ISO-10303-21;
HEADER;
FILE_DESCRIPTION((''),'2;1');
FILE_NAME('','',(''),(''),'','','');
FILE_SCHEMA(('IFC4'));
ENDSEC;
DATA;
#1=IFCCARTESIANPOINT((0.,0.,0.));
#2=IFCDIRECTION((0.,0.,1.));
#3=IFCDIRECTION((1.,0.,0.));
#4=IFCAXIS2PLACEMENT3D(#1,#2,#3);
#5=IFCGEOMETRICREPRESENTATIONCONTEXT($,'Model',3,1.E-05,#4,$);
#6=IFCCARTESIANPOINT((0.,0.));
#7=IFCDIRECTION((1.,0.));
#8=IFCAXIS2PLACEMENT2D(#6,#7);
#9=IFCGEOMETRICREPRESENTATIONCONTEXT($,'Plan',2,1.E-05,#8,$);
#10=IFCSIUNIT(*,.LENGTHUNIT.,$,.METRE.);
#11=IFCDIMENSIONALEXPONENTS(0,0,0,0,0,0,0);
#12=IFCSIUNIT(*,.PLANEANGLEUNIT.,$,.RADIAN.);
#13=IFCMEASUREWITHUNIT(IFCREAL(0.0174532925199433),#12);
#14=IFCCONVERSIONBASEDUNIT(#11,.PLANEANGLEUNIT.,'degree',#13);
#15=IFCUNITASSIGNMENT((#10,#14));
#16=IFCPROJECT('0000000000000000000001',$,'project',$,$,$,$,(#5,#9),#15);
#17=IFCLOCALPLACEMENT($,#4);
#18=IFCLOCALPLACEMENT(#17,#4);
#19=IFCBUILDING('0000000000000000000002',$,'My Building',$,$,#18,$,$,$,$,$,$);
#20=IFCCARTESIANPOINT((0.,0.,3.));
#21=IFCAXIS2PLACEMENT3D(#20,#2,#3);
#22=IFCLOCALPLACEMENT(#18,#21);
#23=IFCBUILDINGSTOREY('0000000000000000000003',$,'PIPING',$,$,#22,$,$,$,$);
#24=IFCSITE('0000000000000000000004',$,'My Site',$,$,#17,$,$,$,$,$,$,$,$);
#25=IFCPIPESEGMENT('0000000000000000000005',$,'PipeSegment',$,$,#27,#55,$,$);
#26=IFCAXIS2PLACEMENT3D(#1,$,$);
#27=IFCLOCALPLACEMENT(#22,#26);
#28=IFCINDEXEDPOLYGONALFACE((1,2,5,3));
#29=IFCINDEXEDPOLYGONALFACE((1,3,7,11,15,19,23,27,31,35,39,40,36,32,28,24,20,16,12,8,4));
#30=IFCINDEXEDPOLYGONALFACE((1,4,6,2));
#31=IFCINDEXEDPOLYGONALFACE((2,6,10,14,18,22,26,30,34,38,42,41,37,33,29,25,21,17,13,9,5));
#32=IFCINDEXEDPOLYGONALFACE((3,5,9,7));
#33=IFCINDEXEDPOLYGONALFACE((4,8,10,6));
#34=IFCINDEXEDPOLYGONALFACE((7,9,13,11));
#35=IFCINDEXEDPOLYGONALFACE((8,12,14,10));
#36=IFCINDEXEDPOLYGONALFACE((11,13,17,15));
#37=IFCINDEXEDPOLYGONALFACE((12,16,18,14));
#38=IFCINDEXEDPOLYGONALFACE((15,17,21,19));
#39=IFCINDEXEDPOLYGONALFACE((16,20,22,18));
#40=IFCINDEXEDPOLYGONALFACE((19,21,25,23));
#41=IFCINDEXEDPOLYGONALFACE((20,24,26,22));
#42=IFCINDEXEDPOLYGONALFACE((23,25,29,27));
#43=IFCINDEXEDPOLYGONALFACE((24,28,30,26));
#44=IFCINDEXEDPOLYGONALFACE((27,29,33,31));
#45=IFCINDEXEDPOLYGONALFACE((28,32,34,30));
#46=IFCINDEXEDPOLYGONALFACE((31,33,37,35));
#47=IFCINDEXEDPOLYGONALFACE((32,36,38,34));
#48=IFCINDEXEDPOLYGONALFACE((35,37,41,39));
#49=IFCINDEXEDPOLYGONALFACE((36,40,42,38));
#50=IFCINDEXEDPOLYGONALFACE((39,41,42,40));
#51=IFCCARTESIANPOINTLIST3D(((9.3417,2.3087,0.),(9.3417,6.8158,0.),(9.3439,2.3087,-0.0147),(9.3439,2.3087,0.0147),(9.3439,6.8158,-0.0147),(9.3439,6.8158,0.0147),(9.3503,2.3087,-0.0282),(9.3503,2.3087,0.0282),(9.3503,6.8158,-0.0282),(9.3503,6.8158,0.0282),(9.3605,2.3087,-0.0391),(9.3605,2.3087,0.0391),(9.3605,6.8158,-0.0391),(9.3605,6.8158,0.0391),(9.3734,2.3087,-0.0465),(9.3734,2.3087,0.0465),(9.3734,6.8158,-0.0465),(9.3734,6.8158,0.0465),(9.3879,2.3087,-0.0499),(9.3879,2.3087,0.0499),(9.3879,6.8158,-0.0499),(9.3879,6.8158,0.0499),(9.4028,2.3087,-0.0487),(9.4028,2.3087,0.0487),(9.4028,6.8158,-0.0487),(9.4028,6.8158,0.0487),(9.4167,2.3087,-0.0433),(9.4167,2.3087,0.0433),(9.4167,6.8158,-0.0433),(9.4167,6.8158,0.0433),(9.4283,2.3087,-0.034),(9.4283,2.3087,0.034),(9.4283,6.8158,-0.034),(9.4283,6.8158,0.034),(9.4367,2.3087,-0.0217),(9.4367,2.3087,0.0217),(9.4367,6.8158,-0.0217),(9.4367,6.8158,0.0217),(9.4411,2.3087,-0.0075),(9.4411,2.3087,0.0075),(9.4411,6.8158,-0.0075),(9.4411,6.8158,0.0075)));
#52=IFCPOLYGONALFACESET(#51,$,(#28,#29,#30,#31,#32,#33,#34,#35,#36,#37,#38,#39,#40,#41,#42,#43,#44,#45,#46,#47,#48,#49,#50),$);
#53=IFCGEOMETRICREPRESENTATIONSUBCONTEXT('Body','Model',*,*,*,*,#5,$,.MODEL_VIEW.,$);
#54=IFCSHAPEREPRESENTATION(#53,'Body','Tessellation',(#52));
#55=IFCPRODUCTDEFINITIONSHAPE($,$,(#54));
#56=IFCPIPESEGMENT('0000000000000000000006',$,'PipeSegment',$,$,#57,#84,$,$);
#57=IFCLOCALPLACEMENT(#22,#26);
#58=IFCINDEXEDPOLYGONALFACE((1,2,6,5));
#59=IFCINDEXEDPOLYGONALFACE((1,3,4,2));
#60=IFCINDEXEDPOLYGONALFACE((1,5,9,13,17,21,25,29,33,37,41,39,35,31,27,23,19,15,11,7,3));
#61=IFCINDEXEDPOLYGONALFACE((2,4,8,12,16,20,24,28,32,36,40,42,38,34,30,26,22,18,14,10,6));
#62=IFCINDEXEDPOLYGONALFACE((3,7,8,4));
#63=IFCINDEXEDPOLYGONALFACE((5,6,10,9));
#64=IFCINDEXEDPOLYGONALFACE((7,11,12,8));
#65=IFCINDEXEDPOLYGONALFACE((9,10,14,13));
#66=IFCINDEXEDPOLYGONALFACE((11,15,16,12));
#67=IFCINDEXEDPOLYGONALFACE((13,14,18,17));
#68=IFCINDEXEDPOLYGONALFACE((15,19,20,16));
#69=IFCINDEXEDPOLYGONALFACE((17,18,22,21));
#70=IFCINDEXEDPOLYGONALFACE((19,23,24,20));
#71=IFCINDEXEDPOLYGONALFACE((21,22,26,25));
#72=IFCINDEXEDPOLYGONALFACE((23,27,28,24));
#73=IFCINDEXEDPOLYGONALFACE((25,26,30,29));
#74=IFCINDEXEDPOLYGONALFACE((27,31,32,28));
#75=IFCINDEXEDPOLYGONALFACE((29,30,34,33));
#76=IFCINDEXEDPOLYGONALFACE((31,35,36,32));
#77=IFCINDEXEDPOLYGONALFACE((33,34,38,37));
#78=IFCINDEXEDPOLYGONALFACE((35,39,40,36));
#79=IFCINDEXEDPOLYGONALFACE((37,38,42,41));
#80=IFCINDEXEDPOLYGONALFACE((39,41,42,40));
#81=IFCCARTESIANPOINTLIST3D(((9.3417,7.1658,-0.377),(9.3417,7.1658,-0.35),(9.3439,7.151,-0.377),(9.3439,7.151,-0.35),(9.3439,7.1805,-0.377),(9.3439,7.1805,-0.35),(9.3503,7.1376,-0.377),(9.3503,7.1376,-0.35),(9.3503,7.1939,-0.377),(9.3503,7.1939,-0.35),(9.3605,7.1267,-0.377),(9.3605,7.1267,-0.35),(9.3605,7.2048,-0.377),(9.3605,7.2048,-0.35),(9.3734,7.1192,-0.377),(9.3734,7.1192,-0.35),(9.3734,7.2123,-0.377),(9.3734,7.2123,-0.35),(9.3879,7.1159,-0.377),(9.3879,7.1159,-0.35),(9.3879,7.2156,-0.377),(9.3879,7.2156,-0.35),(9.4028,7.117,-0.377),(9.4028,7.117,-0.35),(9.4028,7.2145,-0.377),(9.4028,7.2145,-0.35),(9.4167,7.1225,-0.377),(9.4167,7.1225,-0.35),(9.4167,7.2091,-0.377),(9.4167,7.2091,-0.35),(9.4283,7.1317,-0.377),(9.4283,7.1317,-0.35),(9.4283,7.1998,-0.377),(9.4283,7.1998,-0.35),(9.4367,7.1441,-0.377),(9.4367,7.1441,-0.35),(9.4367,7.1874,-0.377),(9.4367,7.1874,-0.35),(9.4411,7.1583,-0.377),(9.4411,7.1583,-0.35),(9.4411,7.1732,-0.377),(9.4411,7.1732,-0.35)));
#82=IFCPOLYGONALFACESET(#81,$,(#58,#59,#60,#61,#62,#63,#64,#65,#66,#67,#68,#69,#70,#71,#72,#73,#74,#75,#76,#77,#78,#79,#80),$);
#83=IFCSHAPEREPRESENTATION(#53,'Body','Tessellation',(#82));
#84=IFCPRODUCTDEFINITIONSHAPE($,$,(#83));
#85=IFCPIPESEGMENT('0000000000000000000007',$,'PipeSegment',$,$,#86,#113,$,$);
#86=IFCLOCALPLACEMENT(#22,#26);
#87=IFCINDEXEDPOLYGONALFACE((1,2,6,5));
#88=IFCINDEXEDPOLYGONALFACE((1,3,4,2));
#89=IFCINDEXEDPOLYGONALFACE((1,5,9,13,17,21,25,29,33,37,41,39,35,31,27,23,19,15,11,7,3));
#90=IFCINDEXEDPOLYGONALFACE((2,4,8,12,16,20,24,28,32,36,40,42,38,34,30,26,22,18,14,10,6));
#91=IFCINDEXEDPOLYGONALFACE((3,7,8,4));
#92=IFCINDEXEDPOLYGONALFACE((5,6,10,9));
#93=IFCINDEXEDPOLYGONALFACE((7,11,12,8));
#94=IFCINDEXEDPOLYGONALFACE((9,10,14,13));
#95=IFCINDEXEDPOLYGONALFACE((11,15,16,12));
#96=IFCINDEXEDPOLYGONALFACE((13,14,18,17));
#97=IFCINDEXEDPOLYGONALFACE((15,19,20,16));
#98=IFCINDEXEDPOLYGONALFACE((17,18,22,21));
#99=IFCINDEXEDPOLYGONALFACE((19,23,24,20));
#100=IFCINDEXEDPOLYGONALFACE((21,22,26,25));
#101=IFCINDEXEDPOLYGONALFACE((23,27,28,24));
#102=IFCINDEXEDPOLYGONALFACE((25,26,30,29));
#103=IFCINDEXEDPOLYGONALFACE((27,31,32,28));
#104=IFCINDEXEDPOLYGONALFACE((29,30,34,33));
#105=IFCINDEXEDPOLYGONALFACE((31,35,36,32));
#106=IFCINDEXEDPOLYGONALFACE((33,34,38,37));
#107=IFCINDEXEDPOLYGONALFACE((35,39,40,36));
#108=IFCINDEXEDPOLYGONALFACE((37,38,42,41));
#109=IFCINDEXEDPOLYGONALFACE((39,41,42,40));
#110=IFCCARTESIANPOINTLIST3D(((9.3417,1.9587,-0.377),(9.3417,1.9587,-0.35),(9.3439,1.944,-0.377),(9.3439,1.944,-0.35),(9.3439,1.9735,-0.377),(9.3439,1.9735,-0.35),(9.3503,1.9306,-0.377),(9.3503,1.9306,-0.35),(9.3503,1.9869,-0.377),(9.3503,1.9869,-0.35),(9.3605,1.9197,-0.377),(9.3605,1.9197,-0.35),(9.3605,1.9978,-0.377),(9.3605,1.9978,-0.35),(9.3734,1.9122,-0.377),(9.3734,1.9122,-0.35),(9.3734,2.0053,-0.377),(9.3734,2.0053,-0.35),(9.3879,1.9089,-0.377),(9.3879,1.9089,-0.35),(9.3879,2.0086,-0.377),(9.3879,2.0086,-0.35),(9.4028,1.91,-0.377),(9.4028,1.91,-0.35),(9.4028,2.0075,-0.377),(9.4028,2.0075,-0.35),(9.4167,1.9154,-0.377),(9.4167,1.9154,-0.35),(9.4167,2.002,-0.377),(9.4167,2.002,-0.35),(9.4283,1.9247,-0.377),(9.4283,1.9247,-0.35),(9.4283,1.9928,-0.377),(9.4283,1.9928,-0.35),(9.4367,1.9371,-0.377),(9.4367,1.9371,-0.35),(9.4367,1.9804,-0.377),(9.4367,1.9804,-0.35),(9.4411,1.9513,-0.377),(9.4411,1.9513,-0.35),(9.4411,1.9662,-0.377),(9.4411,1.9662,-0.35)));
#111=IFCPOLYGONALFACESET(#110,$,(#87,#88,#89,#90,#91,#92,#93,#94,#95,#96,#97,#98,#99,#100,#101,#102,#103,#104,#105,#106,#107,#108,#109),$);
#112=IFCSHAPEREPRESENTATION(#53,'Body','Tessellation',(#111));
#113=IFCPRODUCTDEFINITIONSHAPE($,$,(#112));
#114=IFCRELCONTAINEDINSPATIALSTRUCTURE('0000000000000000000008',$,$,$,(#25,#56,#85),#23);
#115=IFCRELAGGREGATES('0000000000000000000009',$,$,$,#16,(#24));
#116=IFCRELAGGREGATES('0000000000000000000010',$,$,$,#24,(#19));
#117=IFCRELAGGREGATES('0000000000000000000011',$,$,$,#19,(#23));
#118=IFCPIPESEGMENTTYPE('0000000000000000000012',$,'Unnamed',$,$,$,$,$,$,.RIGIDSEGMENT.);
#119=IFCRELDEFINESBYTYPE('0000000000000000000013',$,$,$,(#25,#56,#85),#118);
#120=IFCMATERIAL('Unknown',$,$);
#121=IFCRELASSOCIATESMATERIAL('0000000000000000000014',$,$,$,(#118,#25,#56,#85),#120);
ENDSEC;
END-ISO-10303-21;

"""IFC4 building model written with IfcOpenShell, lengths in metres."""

from ifc_helpers import new_model, entity, si_unit, converted_unit, frame, origin_with_axes, origin_2d_with_axis, place, context, subcontext, project, spatial, circle, extrude, material, material_profile, profile_set, profile_usage, type_object, element, save


model = new_model("IFC4")

# Units and contexts
model_context = context("Model", 3, precision=1e-05, world=origin_with_axes())
plan_context = context("Plan", 2, precision=1e-05, world=origin_2d_with_axis())
body_context = subcontext(model_context, "Body", "Model", "MODEL_VIEW")
ifc_project = project(units=[si_unit("LENGTHUNIT", "METRE"), converted_unit("PLANEANGLEUNIT", "degree", entity("IfcReal", 0.0174532925199433), si_unit("PLANEANGLEUNIT", "RADIAN"), dimensions=[0, 0, 0, 0, 0, 0, 0])], contexts=[model_context, plan_context])

# Site, building, storey
site_placement = place(None, origin_with_axes())
site = spatial("IfcSite", under=ifc_project, at=site_placement, Name="My Site")
building_placement = place(site_placement, origin_with_axes())
building = spatial("IfcBuilding", under=site, at=building_placement, Name="My Building")
storey_placement = place(building_placement, frame((0.0, 0.0, 3.0), z_axis=(0.0, 0.0, 1.0), x_axis=(1.0, 0.0, 0.0)))
storey = spatial("IfcBuildingStorey", under=building, at=storey_placement, Name="PIPING")

# Pipe segments
ifc_material = material(Name="Unknown")
ifc_material_profile = material_profile(ifc_material, circle(Radius=0.05))
ifc_profile_set = profile_set([ifc_material_profile])
pipe_segment_type = type_object("IfcPipeSegmentType", Name="Unnamed", PredefinedType="RIGIDSEGMENT", material=ifc_profile_set)
ifc_profile_usage_1 = profile_usage(ifc_profile_set, cardinal=5)
pipe_segment_1_placement = place(storey_placement, frame((9.3917, 2.3087, 0.0), z_axis=(0.0, 1.0, 0.0), x_axis=(-1.0, 0.0, 0.0)))
element("IfcPipeSegment", 1, at=pipe_segment_1_placement, inside=storey, type_object=pipe_segment_type, material=ifc_profile_usage_1, Name="PipeSegment", context=body_context, shape_type="SweptSolid", body=[
    extrude(circle(Radius=0.05), origin_with_axes(), (0.0, 0.0, 1.0), 4.507),
])
ifc_profile_usage_2 = profile_usage(ifc_profile_set, cardinal=5)
pipe_segment_2_placement = place(storey_placement, frame((9.3917, 7.1658, -0.35), z_axis=(0.0, 0.0, -1.0), x_axis=(-1.0, 0.0, 0.0)))
element("IfcPipeSegment", 2, at=pipe_segment_2_placement, inside=storey, type_object=pipe_segment_type, material=ifc_profile_usage_2, Name="PipeSegment", context=body_context, shape_type="SweptSolid", body=[
    extrude(circle(Radius=0.05), origin_with_axes(), (0.0, 0.0, 1.0), 0.027),
])
ifc_profile_usage_3 = profile_usage(ifc_profile_set, cardinal=5)
pipe_segment_3_placement = place(storey_placement, frame((9.3917, 1.9587, -0.35), z_axis=(0.0, 0.0, -1.0), x_axis=(-1.0, 0.0, 0.0)))
element("IfcPipeSegment", 3, at=pipe_segment_3_placement, inside=storey, type_object=pipe_segment_type, material=ifc_profile_usage_3, Name="PipeSegment", context=body_context, shape_type="SweptSolid", body=[
    extrude(circle(Radius=0.05), origin_with_axes(), (0.0, 0.0, 1.0), 0.027),
])

save(model, "model.ifc")
